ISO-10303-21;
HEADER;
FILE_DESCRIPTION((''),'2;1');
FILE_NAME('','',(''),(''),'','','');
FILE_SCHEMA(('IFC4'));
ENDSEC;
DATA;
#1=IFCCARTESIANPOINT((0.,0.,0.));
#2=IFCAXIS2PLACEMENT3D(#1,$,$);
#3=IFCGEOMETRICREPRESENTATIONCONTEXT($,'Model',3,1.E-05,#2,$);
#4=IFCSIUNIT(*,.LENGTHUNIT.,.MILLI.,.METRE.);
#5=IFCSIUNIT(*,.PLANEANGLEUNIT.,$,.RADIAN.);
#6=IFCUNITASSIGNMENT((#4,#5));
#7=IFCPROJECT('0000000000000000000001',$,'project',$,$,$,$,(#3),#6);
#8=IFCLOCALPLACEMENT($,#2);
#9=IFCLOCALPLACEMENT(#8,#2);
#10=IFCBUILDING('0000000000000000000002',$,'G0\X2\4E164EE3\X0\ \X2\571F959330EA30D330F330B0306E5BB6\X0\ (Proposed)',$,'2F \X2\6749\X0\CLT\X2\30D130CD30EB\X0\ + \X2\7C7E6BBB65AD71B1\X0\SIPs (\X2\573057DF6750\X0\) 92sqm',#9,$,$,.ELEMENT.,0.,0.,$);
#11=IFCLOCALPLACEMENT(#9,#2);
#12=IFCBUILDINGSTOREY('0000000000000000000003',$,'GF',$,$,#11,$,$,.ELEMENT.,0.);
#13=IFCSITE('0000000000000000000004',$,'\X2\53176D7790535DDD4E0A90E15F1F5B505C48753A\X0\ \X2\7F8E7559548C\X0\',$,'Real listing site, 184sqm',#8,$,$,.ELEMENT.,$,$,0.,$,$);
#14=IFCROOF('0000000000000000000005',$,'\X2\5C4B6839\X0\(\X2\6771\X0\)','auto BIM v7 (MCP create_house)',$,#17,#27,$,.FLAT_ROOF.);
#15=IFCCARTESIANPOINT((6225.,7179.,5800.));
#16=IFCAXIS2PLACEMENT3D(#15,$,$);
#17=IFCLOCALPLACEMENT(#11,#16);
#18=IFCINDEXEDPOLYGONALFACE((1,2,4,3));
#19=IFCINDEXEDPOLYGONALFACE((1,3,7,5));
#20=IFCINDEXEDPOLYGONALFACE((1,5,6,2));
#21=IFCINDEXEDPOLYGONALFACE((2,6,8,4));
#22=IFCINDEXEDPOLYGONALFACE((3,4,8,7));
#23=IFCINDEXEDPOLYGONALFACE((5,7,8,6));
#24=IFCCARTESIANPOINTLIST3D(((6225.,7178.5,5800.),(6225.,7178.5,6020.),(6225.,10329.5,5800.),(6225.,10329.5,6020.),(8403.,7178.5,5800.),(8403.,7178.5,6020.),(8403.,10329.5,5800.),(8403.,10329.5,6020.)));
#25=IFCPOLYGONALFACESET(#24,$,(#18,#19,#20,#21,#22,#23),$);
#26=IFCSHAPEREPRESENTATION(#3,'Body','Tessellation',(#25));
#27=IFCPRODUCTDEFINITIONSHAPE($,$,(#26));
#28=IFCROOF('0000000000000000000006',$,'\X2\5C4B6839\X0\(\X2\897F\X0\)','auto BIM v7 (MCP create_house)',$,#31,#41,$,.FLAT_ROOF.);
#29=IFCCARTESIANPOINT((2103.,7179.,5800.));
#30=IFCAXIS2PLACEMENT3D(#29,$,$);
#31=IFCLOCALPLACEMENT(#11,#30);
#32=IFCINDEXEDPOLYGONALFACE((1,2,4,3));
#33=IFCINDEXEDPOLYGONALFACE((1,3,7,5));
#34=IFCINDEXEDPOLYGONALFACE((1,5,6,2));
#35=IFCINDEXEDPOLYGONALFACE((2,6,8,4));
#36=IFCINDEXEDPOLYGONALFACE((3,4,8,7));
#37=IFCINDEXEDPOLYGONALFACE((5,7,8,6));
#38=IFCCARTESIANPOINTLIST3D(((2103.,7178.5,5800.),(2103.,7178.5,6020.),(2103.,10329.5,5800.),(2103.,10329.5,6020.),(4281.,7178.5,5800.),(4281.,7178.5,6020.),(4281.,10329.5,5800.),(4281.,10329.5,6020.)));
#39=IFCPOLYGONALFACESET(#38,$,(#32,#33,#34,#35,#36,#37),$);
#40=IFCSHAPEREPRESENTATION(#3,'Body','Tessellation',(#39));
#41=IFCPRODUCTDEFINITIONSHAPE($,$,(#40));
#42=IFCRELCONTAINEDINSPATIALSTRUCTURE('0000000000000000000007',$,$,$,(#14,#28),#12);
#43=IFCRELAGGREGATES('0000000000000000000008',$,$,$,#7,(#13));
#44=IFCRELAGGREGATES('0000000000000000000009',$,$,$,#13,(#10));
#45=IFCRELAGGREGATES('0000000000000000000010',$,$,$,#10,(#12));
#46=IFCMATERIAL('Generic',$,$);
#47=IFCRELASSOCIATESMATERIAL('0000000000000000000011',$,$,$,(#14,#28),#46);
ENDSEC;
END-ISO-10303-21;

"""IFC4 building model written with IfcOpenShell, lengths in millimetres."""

from ifc_helpers import new_model, si_unit, frame, frame_2d, origin, place, context, project, spatial, rectangle, extrude, material, element, save


model = new_model("IFC4")

# Units and contexts
model_context = context("Model", 3, precision=1e-05, world=origin())
ifc_project = project(units=[si_unit("LENGTHUNIT", "METRE", prefix="MILLI"), si_unit("PLANEANGLEUNIT", "RADIAN")], contexts=[model_context])

# Site, building, storey
site_placement = place(None, origin())
site = spatial("IfcSite", under=ifc_project, at=site_placement, Name="北海道川上郡弟子屈町 美留和", ObjectType="Real listing site, 184sqm", CompositionType="ELEMENT", RefElevation=0.0)
building_placement = place(site_placement, origin())
building = spatial("IfcBuilding", under=site, at=building_placement, Name="G0世代 土間リビングの家 (Proposed)", ObjectType="2F 杉CLTパネル + 籾殻断熱SIPs (地域材) 92sqm", CompositionType="ELEMENT", ElevationOfRefHeight=0.0, ElevationOfTerrain=0.0)
storey_placement = place(building_placement, origin())
storey = spatial("IfcBuildingStorey", under=building, at=storey_placement, Name="GF", CompositionType="ELEMENT", Elevation=0.0)

# Shared definitions
ifc_material = material(Name="Generic")

# Roofs
roof_1_placement = place(storey_placement, frame((6225.0, 7179.0, 5800.0)))
element("IfcRoof", 1, at=roof_1_placement, inside=storey, material=ifc_material, Name="屋根(東)", Description="auto BIM v7 (MCP create_house)", PredefinedType="FLAT_ROOF", context=model_context, shape_type="SweptSolid", body=[
    extrude(rectangle(XDim=2178.0, YDim=3151.0, at=frame_2d((1089.0, 1575.0))), frame((6225.0, 7179.0, 5800.0)), (0.0, 0.0, 1.0), 220.0),
])
roof_2_placement = place(storey_placement, frame((2103.0, 7179.0, 5800.0)))
element("IfcRoof", 2, at=roof_2_placement, inside=storey, material=ifc_material, Name="屋根(西)", Description="auto BIM v7 (MCP create_house)", PredefinedType="FLAT_ROOF", context=model_context, shape_type="SweptSolid", body=[
    extrude(rectangle(XDim=2178.0, YDim=3151.0, at=frame_2d((1089.0, 1575.0))), frame((2103.0, 7179.0, 5800.0)), (0.0, 0.0, 1.0), 220.0),
])

save(model, "model.ifc")
